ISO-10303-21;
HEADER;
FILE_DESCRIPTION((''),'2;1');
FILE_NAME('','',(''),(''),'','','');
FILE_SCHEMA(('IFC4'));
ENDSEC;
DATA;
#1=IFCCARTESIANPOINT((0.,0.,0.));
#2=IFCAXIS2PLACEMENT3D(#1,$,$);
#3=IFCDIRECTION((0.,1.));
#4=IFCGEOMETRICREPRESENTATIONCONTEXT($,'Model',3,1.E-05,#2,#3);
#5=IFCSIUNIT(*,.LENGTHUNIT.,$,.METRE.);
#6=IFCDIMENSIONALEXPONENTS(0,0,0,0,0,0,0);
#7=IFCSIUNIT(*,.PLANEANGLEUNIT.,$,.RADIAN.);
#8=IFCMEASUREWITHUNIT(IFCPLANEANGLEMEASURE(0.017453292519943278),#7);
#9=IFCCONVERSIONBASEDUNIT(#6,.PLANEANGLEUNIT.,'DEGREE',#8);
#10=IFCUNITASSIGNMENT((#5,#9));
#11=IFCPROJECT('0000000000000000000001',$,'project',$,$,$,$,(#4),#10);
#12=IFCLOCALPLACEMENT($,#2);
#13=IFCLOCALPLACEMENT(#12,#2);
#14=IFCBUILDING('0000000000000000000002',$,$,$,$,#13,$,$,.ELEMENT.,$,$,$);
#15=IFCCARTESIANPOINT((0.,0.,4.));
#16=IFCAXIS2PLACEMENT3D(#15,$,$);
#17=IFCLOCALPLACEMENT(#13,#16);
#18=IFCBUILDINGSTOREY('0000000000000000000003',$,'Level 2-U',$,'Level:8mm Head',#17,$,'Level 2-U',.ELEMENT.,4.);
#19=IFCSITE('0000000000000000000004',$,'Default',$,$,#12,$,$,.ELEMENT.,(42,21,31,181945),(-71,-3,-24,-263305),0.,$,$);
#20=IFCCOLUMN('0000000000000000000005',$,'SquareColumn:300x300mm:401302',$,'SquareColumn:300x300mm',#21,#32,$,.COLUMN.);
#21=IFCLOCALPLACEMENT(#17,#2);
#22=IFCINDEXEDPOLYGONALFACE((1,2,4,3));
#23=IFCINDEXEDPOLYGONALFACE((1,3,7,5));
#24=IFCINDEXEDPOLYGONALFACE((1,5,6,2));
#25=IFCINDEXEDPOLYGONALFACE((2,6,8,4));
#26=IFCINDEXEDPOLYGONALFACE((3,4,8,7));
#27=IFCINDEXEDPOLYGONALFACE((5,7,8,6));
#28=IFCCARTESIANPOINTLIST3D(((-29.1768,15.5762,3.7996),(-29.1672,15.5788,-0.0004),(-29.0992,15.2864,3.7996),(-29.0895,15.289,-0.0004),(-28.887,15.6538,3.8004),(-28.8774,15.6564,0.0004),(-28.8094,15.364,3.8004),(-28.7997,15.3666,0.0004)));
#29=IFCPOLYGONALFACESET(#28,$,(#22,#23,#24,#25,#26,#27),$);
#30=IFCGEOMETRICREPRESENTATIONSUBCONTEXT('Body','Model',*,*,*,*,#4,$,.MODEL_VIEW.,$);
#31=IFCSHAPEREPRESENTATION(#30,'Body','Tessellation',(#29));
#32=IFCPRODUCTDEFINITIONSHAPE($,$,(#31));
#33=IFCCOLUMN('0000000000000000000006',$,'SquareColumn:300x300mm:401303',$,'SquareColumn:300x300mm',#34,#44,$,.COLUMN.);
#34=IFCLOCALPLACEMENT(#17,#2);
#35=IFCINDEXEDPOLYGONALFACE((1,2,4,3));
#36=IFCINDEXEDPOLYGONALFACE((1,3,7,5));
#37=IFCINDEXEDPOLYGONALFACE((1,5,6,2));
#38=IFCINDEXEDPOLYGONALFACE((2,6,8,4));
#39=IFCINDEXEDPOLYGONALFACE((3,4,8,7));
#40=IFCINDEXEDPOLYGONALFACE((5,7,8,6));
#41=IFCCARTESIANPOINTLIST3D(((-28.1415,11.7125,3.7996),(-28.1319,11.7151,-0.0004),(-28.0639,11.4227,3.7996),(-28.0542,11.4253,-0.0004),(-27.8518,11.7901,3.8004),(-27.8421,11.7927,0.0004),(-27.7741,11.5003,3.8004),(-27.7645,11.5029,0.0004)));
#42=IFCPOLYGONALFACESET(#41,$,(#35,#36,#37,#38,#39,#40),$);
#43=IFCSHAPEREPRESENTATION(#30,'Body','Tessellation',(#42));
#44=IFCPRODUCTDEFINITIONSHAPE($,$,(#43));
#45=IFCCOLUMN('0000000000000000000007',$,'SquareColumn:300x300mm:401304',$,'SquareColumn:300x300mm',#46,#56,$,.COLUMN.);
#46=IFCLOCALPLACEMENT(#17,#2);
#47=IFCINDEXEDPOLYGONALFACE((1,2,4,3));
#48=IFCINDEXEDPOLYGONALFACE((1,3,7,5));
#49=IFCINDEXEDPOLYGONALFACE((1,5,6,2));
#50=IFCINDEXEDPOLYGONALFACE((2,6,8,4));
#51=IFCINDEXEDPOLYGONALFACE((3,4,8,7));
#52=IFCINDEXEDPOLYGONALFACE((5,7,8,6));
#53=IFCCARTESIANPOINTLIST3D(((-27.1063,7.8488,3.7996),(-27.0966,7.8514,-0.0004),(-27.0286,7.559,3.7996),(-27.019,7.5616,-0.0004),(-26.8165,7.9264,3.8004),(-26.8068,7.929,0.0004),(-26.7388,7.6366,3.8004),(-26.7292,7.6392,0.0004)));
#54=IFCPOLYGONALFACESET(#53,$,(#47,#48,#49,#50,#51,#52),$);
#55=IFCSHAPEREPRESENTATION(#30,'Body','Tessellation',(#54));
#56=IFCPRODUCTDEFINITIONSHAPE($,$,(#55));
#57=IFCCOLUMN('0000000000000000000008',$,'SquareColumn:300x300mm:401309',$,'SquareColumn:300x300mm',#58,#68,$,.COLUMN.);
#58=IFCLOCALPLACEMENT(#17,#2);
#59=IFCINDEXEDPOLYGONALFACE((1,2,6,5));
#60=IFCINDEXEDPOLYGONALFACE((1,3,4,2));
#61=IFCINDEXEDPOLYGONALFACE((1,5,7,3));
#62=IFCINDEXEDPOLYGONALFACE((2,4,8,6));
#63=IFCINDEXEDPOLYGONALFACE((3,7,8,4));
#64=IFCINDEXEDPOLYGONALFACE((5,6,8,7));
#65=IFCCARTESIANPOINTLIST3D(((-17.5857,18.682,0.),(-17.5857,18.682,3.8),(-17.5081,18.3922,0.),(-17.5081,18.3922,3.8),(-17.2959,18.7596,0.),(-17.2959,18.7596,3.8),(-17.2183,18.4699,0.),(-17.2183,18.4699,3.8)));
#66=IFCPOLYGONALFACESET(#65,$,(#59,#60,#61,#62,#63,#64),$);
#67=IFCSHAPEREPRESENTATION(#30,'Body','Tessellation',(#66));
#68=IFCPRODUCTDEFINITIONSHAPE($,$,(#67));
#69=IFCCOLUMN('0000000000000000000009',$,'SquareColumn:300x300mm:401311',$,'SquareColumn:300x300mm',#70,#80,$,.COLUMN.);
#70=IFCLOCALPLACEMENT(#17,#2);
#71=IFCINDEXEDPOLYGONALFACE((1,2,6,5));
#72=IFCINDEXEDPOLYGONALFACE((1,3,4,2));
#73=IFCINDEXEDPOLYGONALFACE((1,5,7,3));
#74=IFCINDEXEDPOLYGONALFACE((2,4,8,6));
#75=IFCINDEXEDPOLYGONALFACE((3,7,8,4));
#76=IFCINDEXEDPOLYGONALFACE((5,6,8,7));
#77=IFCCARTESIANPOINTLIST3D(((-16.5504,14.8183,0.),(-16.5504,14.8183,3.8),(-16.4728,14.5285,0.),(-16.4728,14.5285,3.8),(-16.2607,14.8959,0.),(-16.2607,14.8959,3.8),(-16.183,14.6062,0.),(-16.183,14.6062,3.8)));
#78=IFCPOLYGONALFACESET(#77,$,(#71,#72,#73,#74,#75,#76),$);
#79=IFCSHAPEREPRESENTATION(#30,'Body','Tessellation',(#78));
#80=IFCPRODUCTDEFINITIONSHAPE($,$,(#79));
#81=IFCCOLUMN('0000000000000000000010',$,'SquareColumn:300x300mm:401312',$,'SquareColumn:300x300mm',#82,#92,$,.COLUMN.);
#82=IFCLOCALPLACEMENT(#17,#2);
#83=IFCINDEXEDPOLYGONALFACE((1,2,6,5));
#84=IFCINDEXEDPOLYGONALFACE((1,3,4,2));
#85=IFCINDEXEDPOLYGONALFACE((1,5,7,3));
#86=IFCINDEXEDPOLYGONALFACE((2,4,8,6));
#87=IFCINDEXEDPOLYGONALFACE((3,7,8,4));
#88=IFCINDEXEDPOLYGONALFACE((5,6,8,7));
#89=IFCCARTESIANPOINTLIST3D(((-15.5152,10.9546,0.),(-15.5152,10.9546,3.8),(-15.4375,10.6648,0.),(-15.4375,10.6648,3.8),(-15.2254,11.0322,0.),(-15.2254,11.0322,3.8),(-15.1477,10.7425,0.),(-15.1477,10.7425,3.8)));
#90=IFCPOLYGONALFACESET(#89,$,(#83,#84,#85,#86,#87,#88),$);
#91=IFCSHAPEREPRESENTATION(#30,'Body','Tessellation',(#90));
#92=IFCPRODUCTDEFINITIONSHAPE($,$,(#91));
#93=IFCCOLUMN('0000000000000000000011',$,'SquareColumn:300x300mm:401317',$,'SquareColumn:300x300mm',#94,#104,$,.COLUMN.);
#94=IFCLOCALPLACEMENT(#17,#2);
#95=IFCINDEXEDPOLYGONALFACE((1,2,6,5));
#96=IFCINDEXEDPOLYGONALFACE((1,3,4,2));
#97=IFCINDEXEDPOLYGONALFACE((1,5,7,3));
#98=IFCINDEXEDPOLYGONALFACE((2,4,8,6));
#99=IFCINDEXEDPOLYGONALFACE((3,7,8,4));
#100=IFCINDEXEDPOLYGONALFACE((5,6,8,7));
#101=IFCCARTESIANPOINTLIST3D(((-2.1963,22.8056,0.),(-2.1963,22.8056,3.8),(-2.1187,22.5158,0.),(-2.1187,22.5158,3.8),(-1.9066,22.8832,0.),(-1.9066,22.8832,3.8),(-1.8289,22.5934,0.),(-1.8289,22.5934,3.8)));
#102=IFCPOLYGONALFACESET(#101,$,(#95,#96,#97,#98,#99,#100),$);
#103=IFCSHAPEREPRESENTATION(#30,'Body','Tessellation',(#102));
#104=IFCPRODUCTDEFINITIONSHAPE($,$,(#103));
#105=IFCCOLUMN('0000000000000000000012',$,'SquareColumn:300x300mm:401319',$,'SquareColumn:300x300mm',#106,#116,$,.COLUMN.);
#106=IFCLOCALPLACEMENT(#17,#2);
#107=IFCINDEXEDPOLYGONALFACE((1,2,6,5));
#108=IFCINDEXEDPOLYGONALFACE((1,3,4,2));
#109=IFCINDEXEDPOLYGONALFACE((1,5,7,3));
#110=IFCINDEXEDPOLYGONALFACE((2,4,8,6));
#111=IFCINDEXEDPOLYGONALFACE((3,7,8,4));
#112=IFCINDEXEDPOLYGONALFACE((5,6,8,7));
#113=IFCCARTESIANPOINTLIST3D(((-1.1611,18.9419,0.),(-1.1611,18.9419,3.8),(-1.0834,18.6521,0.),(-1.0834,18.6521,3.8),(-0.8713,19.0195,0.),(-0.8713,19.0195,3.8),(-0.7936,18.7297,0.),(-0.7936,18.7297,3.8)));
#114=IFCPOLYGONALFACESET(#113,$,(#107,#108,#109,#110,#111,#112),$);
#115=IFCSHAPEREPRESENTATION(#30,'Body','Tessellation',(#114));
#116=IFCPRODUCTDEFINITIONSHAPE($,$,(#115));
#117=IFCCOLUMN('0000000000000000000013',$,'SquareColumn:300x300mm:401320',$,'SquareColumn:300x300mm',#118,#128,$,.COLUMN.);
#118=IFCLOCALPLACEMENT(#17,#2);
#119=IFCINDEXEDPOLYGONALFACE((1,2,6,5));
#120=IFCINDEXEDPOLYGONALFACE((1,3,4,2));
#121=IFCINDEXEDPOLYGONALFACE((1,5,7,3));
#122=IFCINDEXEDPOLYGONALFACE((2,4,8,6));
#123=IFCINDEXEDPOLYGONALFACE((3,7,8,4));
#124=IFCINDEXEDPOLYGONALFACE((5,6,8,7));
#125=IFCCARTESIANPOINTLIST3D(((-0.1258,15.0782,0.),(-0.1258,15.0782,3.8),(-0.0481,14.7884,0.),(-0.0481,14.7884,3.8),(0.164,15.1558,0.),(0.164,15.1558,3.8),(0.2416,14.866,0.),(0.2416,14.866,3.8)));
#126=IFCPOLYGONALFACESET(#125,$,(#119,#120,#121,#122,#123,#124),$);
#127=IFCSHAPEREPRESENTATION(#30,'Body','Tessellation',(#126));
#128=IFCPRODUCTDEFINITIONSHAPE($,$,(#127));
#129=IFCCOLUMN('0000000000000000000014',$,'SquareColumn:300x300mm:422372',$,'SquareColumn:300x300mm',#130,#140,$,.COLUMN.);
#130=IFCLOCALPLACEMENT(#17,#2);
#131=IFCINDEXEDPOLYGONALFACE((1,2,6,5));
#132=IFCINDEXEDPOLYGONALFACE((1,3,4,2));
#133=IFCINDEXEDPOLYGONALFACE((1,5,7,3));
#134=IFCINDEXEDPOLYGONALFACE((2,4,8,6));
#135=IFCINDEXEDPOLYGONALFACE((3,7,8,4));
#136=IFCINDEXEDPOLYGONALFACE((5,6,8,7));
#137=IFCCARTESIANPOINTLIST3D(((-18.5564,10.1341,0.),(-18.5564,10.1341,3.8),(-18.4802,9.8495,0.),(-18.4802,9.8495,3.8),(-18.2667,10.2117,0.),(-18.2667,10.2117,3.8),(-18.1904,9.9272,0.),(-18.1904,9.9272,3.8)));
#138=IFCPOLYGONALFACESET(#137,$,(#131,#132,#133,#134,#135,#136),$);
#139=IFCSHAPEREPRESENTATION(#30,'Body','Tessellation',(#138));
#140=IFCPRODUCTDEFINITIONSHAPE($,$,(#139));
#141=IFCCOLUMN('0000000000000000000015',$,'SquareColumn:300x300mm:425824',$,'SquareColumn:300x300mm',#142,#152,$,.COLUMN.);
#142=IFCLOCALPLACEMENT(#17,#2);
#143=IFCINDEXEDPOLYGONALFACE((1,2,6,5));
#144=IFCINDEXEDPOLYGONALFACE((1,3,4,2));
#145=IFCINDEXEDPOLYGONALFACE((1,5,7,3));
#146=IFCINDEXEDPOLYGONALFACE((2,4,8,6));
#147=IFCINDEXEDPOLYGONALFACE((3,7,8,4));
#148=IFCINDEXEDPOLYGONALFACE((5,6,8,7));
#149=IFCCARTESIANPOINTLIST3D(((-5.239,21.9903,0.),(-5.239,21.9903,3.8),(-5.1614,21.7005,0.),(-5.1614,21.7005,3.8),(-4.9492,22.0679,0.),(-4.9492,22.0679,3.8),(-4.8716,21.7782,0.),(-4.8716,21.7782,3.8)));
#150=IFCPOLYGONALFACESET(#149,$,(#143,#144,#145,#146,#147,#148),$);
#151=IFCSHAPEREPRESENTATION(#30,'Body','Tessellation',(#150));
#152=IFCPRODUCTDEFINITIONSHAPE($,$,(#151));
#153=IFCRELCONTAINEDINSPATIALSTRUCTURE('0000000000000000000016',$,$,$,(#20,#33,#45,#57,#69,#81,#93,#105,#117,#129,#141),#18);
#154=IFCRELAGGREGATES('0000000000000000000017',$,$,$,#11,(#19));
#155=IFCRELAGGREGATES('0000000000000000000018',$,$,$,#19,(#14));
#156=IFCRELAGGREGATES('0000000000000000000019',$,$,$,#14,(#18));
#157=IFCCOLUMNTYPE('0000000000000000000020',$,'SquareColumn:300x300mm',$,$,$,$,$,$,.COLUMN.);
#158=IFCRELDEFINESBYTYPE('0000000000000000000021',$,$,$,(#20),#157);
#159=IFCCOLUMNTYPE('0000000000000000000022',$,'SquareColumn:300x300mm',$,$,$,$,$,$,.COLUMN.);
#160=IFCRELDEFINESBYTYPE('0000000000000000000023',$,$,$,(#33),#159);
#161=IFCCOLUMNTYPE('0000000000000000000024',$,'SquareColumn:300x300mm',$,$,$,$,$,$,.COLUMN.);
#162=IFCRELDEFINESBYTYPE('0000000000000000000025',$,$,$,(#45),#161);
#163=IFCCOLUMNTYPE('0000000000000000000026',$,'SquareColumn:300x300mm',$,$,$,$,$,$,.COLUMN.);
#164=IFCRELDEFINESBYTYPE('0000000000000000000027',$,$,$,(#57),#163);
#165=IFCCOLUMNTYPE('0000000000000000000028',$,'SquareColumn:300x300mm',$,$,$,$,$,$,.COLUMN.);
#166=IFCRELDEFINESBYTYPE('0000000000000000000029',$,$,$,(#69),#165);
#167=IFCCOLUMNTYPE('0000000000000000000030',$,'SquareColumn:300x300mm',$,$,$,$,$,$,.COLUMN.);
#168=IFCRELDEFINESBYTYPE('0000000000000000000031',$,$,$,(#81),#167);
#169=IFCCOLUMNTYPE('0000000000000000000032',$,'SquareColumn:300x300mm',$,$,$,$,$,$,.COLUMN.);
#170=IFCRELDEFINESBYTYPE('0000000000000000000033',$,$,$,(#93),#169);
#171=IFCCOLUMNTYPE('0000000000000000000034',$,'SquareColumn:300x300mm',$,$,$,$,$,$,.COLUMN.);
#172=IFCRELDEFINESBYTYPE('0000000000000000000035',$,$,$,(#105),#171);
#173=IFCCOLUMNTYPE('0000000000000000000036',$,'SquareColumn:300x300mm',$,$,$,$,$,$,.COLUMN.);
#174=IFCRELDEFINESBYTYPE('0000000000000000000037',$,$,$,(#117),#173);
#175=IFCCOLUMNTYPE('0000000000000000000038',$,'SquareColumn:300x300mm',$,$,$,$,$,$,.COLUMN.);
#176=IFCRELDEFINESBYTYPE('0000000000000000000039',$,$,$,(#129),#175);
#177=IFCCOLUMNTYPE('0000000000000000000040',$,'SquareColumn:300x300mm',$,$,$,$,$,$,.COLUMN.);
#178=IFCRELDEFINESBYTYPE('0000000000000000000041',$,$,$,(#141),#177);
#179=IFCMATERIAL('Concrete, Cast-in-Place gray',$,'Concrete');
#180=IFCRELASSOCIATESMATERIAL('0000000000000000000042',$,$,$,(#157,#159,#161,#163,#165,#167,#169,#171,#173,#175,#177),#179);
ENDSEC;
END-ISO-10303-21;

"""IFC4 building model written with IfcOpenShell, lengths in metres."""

from ifc_helpers import new_model, entity, si_unit, converted_unit, direction, frame, frame_2d, origin, origin_2d_with_axis, place, context, subcontext, project, spatial, rectangle, extrude, source, transform, mapped, material, material_profile, profile_set, type_object, type_shapes, element, save


model = new_model("IFC4")

# Units and contexts
model_context = context("Model", 3, precision=1e-05, world=origin(), true_north=direction((0.0, 1.0)))
body_context = subcontext(model_context, "Body", "Model", "MODEL_VIEW")
ifc_project = project(units=[si_unit("LENGTHUNIT", "METRE"), converted_unit("PLANEANGLEUNIT", "DEGREE", entity("IfcPlaneAngleMeasure", 0.017453292519943278), si_unit("PLANEANGLEUNIT", "RADIAN"), dimensions=[0, 0, 0, 0, 0, 0, 0])], contexts=[model_context])

# Site, building, storey
site_placement = place(None, origin())
site = spatial("IfcSite", under=ifc_project, at=site_placement, Name="Default", CompositionType="ELEMENT", RefLatitude=(42, 21, 31, 181945), RefLongitude=(-71, -3, -24, -263305), RefElevation=0.0)
building_placement = place(site_placement, origin())
building = spatial("IfcBuilding", under=site, at=building_placement, CompositionType="ELEMENT")
storey_placement = place(building_placement, frame((0.0, 0.0, 4.0)))
storey = spatial("IfcBuildingStorey", under=building, at=storey_placement, Name="Level 2-U", ObjectType="Level:8mm Head", LongName="Level 2-U", CompositionType="ELEMENT", Elevation=4.0)

# Columns
ifc_material_1 = material(Name="Concrete, Cast-in-Place gray", Category="Concrete")
ifc_material_profile = material_profile(ifc_material_1, rectangle(XDim=0.3, YDim=0.3, at=origin_2d_with_axis()), Name="300x300mm")
ifc_profile_set = profile_set([ifc_material_profile], Name="300x300mm")
column_type_1 = type_object("IfcColumnType", Name="SquareColumn:300x300mm", PredefinedType="COLUMN", material=ifc_profile_set)
shared_shape_1 = source(origin(), body_context, "Body", "SweptSolid", [
    extrude(rectangle(XDim=0.3, YDim=0.3, at=frame_2d((0.0, 0.0), x_axis=(0.0, 1.0))), frame((-28.9835, 15.4727, 4.0), z_axis=(-0.002542, -0.000681, 0.999997), x_axis=(-0.258819, 0.965926, 0.0)), (0.0, 0.0, 1.0), 3.8),
])
type_shapes(column_type_1, [shared_shape_1])
column_1_placement = place(storey_placement, frame((0.0, 0.0, -4.0)))
element("IfcColumn", 1, at=column_1_placement, inside=storey, type_object=column_type_1, Name="SquareColumn:300x300mm:401302", ObjectType="SquareColumn:300x300mm", PredefinedType="COLUMN", context=body_context, shape_type="MappedRepresentation", body=[
    mapped(shared_shape_1, transform((0.0, 0.0, 0.0), scale=1.0)),
])
column_type_2 = type_object("IfcColumnType", Name="SquareColumn:300x300mm", PredefinedType="COLUMN", material=ifc_profile_set)
shared_shape_2 = source(origin(), body_context, "Body", "SweptSolid", [
    extrude(rectangle(XDim=0.3, YDim=0.3, at=frame_2d((0.0, 0.0), x_axis=(0.0, 1.0))), frame((-27.9482, 11.609, 4.0), z_axis=(-0.002542, -0.000681, 0.999997), x_axis=(-0.258819, 0.965926, 0.0)), (0.0, 0.0, 1.0), 3.8),
])
type_shapes(column_type_2, [shared_shape_2])
column_2_placement = place(storey_placement, frame((0.0, 0.0, -4.0)))
element("IfcColumn", 2, at=column_2_placement, inside=storey, type_object=column_type_2, Name="SquareColumn:300x300mm:401303", ObjectType="SquareColumn:300x300mm", PredefinedType="COLUMN", context=body_context, shape_type="MappedRepresentation", body=[
    mapped(shared_shape_2, transform((0.0, 0.0, 0.0), scale=1.0)),
])
column_type_3 = type_object("IfcColumnType", Name="SquareColumn:300x300mm", PredefinedType="COLUMN", material=ifc_profile_set)
shared_shape_3 = source(origin(), body_context, "Body", "SweptSolid", [
    extrude(rectangle(XDim=0.3, YDim=0.3, at=frame_2d((0.0, 0.0), x_axis=(0.0, 1.0))), frame((-26.9129, 7.7453, 4.0), z_axis=(-0.002542, -0.000681, 0.999997), x_axis=(-0.258819, 0.965926, 0.0)), (0.0, 0.0, 1.0), 3.8),
])
type_shapes(column_type_3, [shared_shape_3])
column_3_placement = place(storey_placement, frame((0.0, 0.0, -4.0)))
element("IfcColumn", 3, at=column_3_placement, inside=storey, type_object=column_type_3, Name="SquareColumn:300x300mm:401304", ObjectType="SquareColumn:300x300mm", PredefinedType="COLUMN", context=body_context, shape_type="MappedRepresentation", body=[
    mapped(shared_shape_3, transform((0.0, 0.0, 0.0), scale=1.0)),
])
column_type_4 = type_object("IfcColumnType", Name="SquareColumn:300x300mm", PredefinedType="COLUMN", material=ifc_profile_set)
shared_shape_4 = source(origin(), body_context, "Body", "SweptSolid", [
    extrude(rectangle(XDim=0.3, YDim=0.3, at=origin_2d_with_axis()), frame((-17.402, 18.5759, 4.0), z_axis=(0.0, 0.0, 1.0), x_axis=(-0.258819, 0.965926, 0.0)), (0.0, 0.0, 1.0), 3.8),
])
type_shapes(column_type_4, [shared_shape_4])
column_4_placement = place(storey_placement, frame((0.0, 0.0, -4.0)))
element("IfcColumn", 4, at=column_4_placement, inside=storey, type_object=column_type_4, Name="SquareColumn:300x300mm:401309", ObjectType="SquareColumn:300x300mm", PredefinedType="COLUMN", context=body_context, shape_type="MappedRepresentation", body=[
    mapped(shared_shape_4, transform((0.0, 0.0, 0.0), scale=1.0)),
])
column_type_5 = type_object("IfcColumnType", Name="SquareColumn:300x300mm", PredefinedType="COLUMN", material=ifc_profile_set)
shared_shape_5 = source(origin(), body_context, "Body", "SweptSolid", [
    extrude(rectangle(XDim=0.3, YDim=0.3, at=frame_2d((0.0, 0.0), x_axis=(1.0, 0.0))), frame((-16.3667, 14.7122, 4.0), z_axis=(0.0, 0.0, 1.0), x_axis=(-0.258819, 0.965926, 0.0)), (0.0, 0.0, 1.0), 3.8),
])
type_shapes(column_type_5, [shared_shape_5])
column_5_placement = place(storey_placement, frame((0.0, 0.0, -4.0)))
element("IfcColumn", 5, at=column_5_placement, inside=storey, type_object=column_type_5, Name="SquareColumn:300x300mm:401311", ObjectType="SquareColumn:300x300mm", PredefinedType="COLUMN", context=body_context, shape_type="MappedRepresentation", body=[
    mapped(shared_shape_5, transform((0.0, 0.0, 0.0), scale=1.0)),
])
column_type_6 = type_object("IfcColumnType", Name="SquareColumn:300x300mm", PredefinedType="COLUMN", material=ifc_profile_set)
shared_shape_6 = source(origin(), body_context, "Body", "SweptSolid", [
    extrude(rectangle(XDim=0.3, YDim=0.3, at=frame_2d((0.0, 0.0), x_axis=(1.0, 0.0))), frame((-15.3314, 10.8485, 4.0), z_axis=(0.0, 0.0, 1.0), x_axis=(-0.258819, 0.965926, 0.0)), (0.0, 0.0, 1.0), 3.8),
])
type_shapes(column_type_6, [shared_shape_6])
column_6_placement = place(storey_placement, frame((0.0, 0.0, -4.0)))
element("IfcColumn", 6, at=column_6_placement, inside=storey, type_object=column_type_6, Name="SquareColumn:300x300mm:401312", ObjectType="SquareColumn:300x300mm", PredefinedType="COLUMN", context=body_context, shape_type="MappedRepresentation", body=[
    mapped(shared_shape_6, transform((0.0, 0.0, 0.0), scale=1.0)),
])
column_type_7 = type_object("IfcColumnType", Name="SquareColumn:300x300mm", PredefinedType="COLUMN", material=ifc_profile_set)
shared_shape_7 = source(origin(), body_context, "Body", "SweptSolid", [
    extrude(rectangle(XDim=0.3, YDim=0.3, at=frame_2d((0.0, 0.0), x_axis=(1.0, 0.0))), frame((-2.0126, 22.6995, 4.0), z_axis=(0.0, 0.0, 1.0), x_axis=(-0.258819, 0.965926, 0.0)), (0.0, 0.0, 1.0), 3.8),
])
type_shapes(column_type_7, [shared_shape_7])
column_7_placement = place(storey_placement, frame((0.0, 0.0, -4.0)))
element("IfcColumn", 7, at=column_7_placement, inside=storey, type_object=column_type_7, Name="SquareColumn:300x300mm:401317", ObjectType="SquareColumn:300x300mm", PredefinedType="COLUMN", context=body_context, shape_type="MappedRepresentation", body=[
    mapped(shared_shape_7, transform((0.0, 0.0, 0.0), scale=1.0)),
])
column_type_8 = type_object("IfcColumnType", Name="SquareColumn:300x300mm", PredefinedType="COLUMN", material=ifc_profile_set)
shared_shape_8 = source(origin(), body_context, "Body", "SweptSolid", [
    extrude(rectangle(XDim=0.3, YDim=0.3, at=frame_2d((0.0, 0.0), x_axis=(1.0, 0.0))), frame((-0.9774, 18.8358, 4.0), z_axis=(0.0, 0.0, 1.0), x_axis=(-0.258819, 0.965926, 0.0)), (0.0, 0.0, 1.0), 3.8),
])
type_shapes(column_type_8, [shared_shape_8])
column_8_placement = place(storey_placement, frame((0.0, 0.0, -4.0)))
element("IfcColumn", 8, at=column_8_placement, inside=storey, type_object=column_type_8, Name="SquareColumn:300x300mm:401319", ObjectType="SquareColumn:300x300mm", PredefinedType="COLUMN", context=body_context, shape_type="MappedRepresentation", body=[
    mapped(shared_shape_8, transform((0.0, 0.0, 0.0), scale=1.0)),
])
column_type_9 = type_object("IfcColumnType", Name="SquareColumn:300x300mm", PredefinedType="COLUMN", material=ifc_profile_set)
shared_shape_9 = source(origin(), body_context, "Body", "SweptSolid", [
    extrude(rectangle(XDim=0.3, YDim=0.3, at=origin_2d_with_axis()), frame((0.0579, 14.9721, 4.0), z_axis=(0.0, 0.0, 1.0), x_axis=(-0.258819, 0.965926, 0.0)), (0.0, 0.0, 1.0), 3.8),
])
type_shapes(column_type_9, [shared_shape_9])
column_9_placement = place(storey_placement, frame((0.0, 0.0, -4.0)))
element("IfcColumn", 9, at=column_9_placement, inside=storey, type_object=column_type_9, Name="SquareColumn:300x300mm:401320", ObjectType="SquareColumn:300x300mm", PredefinedType="COLUMN", context=body_context, shape_type="MappedRepresentation", body=[
    mapped(shared_shape_9, transform((0.0, 0.0, 0.0), scale=1.0)),
])
column_type_10 = type_object("IfcColumnType", Name="SquareColumn:300x300mm", PredefinedType="COLUMN", material=ifc_profile_set)
shared_shape_10 = source(origin(), body_context, "Body", "SweptSolid", [
    extrude(rectangle(XDim=0.2946, YDim=0.3, at=frame_2d((0.0, 0.0), x_axis=(1.0, 0.0))), frame((-18.3734, 10.0306, 4.0), z_axis=(0.0, 0.0, 1.0), x_axis=(-0.258819, 0.965926, 0.0)), (0.0, 0.0, 1.0), 3.8),
])
type_shapes(column_type_10, [shared_shape_10])
column_10_placement = place(storey_placement, frame((0.0, 0.0, -4.0)))
element("IfcColumn", 10, at=column_10_placement, inside=storey, type_object=column_type_10, Name="SquareColumn:300x300mm:422372", ObjectType="SquareColumn:300x300mm", PredefinedType="COLUMN", context=body_context, shape_type="MappedRepresentation", body=[
    mapped(shared_shape_10, transform((0.0, 0.0, 0.0), scale=1.0)),
])
column_type_11 = type_object("IfcColumnType", Name="SquareColumn:300x300mm", PredefinedType="COLUMN", material=ifc_profile_set)
shared_shape_11 = source(origin(), body_context, "Body", "SweptSolid", [
    extrude(rectangle(XDim=0.3, YDim=0.3, at=frame_2d((0.0, 0.0), x_axis=(1.0, 0.0))), frame((-5.0553, 21.8842, 4.0), z_axis=(0.0, 0.0, 1.0), x_axis=(-0.258819, 0.965926, 0.0)), (0.0, 0.0, 1.0), 3.8),
])
type_shapes(column_type_11, [shared_shape_11])
column_11_placement = place(storey_placement, frame((0.0, 0.0, -4.0)))
element("IfcColumn", 11, at=column_11_placement, inside=storey, type_object=column_type_11, Name="SquareColumn:300x300mm:425824", ObjectType="SquareColumn:300x300mm", PredefinedType="COLUMN", context=body_context, shape_type="MappedRepresentation", body=[
    mapped(shared_shape_11, transform((0.0, 0.0, 0.0), scale=1.0)),
])

save(model, "model.ifc")
